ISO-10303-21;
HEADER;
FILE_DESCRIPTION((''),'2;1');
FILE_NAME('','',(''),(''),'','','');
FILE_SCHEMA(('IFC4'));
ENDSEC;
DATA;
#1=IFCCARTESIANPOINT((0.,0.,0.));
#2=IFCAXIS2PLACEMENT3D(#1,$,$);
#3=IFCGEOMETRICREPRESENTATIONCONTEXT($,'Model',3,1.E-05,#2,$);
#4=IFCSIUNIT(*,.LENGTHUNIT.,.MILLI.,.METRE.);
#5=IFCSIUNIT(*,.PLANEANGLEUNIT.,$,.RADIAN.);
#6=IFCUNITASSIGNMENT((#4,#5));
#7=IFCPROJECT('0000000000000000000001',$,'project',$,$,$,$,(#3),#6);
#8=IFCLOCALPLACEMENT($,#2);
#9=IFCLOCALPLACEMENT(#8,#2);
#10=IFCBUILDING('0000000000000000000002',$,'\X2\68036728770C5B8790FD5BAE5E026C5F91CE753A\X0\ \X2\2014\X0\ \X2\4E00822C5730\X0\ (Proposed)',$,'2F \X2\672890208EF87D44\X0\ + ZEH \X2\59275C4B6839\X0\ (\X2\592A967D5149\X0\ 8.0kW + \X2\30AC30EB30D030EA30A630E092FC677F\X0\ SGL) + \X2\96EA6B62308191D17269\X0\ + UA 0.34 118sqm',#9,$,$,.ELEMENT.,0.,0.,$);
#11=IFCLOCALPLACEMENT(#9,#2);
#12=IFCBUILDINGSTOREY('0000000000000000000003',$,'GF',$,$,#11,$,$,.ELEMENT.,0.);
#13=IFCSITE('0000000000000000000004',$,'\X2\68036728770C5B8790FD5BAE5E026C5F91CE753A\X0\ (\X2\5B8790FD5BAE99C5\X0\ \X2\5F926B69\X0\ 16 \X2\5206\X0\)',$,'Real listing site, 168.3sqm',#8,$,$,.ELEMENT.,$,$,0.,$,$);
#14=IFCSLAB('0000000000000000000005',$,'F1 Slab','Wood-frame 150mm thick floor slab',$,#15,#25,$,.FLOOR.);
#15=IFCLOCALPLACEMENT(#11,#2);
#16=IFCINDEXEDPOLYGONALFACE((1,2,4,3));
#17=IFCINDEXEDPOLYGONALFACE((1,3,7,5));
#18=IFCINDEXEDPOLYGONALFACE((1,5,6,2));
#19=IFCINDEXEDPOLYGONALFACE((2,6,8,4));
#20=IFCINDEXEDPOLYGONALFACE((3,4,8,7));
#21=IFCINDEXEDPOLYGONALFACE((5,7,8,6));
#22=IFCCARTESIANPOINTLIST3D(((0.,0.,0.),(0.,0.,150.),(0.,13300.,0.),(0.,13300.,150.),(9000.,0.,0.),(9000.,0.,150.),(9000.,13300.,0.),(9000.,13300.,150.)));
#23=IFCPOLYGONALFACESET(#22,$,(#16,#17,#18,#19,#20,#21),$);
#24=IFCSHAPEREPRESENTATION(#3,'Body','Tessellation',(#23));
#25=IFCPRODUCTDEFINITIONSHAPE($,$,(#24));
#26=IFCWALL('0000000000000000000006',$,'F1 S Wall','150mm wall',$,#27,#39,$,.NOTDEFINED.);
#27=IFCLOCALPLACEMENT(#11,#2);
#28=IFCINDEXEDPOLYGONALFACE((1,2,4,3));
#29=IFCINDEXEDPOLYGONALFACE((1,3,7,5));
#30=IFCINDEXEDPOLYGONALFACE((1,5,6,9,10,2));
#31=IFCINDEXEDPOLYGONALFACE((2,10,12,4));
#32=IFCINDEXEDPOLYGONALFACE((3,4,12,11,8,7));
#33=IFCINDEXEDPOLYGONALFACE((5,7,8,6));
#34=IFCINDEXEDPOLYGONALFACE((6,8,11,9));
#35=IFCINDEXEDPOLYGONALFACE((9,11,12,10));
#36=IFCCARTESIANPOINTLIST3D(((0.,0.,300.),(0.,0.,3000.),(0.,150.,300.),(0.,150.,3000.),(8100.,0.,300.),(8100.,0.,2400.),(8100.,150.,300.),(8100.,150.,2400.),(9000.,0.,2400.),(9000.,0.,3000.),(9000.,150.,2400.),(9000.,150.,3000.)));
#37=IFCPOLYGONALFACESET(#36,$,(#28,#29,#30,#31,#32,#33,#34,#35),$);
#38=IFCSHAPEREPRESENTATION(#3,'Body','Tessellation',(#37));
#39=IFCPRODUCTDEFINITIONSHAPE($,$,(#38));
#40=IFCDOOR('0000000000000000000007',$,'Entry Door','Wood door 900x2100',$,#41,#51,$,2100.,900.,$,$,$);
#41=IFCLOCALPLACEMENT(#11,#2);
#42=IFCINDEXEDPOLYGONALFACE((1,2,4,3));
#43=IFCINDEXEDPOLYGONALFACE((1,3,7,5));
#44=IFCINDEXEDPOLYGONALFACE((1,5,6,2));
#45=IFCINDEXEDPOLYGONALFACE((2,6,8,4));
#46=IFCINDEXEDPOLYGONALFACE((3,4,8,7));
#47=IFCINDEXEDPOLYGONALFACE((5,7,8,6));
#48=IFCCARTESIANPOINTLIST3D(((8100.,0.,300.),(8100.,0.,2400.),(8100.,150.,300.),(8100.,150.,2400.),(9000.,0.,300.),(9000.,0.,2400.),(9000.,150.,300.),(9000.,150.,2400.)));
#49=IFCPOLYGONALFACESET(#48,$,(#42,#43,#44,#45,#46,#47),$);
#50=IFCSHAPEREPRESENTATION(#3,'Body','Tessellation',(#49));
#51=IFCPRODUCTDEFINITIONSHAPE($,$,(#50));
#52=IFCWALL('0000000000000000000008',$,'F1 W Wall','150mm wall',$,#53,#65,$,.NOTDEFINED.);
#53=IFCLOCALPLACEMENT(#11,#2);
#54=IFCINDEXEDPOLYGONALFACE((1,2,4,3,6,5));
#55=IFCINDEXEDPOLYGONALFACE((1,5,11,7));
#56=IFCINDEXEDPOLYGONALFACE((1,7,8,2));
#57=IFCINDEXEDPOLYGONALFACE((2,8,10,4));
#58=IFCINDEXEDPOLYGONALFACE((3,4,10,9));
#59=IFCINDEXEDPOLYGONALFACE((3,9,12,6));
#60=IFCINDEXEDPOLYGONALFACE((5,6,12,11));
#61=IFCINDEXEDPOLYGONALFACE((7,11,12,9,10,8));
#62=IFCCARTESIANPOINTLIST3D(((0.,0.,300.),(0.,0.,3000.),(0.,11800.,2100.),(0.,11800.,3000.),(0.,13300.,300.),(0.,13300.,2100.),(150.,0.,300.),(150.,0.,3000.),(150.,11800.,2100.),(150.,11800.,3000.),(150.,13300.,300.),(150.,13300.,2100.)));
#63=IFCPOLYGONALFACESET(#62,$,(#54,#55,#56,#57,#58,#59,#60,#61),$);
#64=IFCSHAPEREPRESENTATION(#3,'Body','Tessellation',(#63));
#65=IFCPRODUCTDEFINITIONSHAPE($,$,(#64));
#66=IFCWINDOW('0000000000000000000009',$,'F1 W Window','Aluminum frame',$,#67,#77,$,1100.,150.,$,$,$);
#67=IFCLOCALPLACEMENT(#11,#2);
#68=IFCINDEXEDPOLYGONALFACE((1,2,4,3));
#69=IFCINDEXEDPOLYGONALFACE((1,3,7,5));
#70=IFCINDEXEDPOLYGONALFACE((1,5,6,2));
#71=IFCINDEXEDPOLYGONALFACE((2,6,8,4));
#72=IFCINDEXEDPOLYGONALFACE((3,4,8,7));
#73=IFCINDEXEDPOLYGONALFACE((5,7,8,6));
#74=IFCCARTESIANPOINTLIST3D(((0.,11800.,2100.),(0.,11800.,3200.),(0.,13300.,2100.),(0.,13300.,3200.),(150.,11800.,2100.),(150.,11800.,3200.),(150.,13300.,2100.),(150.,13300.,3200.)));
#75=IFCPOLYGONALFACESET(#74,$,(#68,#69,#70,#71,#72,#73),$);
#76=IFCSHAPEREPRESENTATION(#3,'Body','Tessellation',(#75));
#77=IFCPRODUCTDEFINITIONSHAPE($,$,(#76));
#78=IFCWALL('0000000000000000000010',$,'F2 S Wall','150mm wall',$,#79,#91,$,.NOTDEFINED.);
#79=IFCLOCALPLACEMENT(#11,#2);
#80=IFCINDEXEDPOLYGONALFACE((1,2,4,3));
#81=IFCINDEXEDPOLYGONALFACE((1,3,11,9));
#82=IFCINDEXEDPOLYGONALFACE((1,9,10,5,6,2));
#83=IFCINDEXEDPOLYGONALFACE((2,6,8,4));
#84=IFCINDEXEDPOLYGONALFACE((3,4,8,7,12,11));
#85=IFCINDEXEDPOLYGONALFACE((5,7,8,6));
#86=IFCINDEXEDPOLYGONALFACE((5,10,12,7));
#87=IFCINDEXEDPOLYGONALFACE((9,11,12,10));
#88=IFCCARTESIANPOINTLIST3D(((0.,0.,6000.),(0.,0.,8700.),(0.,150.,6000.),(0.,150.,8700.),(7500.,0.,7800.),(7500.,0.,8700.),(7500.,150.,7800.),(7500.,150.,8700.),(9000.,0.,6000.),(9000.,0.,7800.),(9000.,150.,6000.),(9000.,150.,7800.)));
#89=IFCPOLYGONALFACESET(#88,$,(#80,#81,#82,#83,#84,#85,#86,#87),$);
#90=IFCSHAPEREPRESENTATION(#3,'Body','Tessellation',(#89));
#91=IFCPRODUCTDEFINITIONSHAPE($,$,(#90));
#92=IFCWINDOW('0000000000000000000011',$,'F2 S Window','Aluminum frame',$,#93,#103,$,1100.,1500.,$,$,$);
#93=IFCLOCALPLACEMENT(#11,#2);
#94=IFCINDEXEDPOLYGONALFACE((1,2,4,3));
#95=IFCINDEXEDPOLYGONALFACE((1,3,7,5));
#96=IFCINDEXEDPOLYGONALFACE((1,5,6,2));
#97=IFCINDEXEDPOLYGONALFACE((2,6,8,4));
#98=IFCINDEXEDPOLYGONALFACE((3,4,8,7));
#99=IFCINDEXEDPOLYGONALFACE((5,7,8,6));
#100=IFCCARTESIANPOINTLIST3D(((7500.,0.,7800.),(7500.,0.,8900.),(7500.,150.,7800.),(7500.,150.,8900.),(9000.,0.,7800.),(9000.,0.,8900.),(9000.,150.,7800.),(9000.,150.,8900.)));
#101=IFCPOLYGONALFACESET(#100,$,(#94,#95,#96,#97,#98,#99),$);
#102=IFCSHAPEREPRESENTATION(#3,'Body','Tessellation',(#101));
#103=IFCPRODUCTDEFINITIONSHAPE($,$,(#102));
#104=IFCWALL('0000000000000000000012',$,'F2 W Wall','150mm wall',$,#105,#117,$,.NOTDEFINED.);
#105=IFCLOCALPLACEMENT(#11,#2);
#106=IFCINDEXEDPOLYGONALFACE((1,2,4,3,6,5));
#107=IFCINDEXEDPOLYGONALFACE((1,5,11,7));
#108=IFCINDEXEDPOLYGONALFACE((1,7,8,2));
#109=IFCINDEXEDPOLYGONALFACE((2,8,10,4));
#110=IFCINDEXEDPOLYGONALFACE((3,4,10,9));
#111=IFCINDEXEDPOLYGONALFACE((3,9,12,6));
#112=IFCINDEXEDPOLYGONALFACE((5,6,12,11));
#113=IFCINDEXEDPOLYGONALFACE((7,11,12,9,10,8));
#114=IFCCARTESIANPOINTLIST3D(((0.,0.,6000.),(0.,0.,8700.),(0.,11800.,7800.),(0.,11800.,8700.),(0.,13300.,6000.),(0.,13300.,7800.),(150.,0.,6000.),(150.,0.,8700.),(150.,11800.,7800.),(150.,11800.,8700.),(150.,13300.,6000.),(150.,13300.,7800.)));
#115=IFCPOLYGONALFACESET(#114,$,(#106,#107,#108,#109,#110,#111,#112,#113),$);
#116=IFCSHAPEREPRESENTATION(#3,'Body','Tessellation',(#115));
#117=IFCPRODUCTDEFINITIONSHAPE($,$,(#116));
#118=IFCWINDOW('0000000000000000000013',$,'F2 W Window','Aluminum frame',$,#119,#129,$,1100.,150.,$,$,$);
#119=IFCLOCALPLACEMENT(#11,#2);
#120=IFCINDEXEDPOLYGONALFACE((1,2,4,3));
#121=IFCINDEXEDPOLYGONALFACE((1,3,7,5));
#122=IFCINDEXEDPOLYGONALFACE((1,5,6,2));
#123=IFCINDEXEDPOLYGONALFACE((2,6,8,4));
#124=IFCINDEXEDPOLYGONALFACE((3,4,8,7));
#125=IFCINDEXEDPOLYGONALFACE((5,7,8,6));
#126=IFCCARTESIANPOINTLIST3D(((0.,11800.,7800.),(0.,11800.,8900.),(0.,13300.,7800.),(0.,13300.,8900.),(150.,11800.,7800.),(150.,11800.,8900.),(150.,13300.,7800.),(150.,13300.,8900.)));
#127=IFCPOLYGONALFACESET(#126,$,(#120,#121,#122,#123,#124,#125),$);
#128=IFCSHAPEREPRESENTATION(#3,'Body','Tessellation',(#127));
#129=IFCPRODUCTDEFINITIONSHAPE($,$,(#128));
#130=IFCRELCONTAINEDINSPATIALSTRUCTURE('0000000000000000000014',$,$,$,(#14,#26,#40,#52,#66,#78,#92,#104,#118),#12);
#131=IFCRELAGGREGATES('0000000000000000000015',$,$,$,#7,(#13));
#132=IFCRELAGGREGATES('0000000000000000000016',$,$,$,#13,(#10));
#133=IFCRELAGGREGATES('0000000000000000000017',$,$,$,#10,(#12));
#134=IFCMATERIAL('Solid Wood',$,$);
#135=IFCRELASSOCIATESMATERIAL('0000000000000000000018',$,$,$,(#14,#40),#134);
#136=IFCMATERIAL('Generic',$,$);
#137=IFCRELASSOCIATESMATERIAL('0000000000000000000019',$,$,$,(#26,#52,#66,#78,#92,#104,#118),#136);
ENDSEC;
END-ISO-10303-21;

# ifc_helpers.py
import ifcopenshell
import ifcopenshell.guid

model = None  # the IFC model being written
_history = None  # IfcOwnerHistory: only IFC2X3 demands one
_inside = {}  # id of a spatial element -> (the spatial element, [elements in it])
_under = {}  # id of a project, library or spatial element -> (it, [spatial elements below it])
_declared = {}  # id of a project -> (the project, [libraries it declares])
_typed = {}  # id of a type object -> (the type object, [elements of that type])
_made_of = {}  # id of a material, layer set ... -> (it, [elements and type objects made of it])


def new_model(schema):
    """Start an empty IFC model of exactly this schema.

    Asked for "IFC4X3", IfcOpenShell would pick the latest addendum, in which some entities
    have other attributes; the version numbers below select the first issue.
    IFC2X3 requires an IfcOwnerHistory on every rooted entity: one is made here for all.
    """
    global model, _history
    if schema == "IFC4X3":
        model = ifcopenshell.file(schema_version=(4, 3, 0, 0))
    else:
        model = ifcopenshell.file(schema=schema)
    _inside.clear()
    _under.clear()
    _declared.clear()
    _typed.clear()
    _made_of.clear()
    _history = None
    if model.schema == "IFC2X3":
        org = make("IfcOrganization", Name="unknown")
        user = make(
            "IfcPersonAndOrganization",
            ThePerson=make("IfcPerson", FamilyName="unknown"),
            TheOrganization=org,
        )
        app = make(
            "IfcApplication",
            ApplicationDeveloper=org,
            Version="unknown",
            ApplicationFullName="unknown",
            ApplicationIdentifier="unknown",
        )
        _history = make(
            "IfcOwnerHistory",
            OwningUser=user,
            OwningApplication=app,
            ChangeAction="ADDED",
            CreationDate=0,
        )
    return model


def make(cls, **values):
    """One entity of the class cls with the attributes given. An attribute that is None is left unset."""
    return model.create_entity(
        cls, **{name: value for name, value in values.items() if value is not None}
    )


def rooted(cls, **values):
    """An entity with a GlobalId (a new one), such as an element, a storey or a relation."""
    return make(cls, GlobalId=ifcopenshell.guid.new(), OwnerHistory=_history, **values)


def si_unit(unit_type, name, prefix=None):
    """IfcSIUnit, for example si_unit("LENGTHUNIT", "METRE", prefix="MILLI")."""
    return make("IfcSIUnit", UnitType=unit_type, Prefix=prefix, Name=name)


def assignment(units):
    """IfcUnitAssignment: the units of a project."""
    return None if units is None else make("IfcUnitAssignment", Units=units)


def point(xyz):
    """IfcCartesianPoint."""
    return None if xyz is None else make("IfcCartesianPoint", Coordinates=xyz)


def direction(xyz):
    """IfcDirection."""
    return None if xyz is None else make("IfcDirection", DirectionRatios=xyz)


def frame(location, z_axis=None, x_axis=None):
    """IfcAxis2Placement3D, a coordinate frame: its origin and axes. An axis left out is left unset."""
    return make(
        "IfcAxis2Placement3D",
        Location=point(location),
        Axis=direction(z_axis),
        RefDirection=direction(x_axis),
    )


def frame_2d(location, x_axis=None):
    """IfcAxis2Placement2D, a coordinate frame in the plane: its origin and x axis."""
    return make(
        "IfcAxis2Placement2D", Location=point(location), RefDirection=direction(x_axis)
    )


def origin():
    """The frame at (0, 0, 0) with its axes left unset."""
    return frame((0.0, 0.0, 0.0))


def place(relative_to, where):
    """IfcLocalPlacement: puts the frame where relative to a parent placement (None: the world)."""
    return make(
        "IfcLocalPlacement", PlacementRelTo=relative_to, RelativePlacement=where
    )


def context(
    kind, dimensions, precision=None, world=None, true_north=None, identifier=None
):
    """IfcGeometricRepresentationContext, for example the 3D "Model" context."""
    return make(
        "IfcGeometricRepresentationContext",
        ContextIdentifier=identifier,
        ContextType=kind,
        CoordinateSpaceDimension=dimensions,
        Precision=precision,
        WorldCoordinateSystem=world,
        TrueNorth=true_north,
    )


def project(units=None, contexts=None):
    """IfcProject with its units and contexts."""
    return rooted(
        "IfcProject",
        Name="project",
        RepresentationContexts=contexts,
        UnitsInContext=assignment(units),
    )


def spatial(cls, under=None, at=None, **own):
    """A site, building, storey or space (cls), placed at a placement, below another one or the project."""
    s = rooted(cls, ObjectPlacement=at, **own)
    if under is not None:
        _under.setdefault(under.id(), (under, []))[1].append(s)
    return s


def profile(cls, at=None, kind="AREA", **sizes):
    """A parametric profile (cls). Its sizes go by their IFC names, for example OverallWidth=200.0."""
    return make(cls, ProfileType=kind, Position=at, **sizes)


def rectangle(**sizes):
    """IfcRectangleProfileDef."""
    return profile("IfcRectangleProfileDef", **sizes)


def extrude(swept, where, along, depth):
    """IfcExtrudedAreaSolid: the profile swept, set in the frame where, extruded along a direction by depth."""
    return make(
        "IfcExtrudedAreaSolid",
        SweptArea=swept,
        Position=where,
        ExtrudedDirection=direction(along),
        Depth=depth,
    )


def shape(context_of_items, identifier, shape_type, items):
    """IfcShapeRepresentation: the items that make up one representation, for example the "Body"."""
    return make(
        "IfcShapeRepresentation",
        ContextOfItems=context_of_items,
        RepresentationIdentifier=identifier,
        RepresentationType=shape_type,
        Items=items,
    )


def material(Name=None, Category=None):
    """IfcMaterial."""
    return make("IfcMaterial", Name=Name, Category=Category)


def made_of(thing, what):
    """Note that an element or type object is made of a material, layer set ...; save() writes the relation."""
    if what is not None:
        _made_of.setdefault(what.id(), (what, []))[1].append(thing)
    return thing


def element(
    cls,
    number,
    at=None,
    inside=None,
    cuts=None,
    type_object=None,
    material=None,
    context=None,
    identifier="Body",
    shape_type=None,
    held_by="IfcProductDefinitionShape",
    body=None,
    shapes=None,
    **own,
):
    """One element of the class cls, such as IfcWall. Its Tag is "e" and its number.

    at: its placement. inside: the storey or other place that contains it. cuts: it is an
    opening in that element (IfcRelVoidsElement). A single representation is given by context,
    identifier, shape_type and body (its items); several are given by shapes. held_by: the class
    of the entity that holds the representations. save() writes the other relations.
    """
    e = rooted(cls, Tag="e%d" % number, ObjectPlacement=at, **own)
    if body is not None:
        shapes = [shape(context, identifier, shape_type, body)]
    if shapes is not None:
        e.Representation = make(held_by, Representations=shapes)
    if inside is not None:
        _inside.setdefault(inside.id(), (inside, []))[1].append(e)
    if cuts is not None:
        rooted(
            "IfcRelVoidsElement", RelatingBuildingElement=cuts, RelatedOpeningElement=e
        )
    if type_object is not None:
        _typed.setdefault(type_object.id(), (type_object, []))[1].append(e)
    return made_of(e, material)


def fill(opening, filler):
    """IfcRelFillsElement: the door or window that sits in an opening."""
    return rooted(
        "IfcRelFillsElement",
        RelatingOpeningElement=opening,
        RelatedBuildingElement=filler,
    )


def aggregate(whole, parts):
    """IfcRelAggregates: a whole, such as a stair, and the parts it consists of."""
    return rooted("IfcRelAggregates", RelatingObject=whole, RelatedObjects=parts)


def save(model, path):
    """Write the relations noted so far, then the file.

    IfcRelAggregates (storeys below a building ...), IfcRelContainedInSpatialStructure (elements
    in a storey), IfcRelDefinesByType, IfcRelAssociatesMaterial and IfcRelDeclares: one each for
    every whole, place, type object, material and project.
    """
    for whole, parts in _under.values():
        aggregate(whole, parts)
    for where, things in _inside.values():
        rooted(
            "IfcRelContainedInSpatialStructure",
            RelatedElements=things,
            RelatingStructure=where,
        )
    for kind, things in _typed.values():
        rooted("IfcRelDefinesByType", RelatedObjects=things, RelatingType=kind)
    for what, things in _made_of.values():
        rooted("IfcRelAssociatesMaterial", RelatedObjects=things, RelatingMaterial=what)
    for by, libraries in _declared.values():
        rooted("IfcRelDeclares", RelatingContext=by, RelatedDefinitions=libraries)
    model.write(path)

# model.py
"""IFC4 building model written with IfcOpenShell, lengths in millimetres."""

from ifc_helpers import new_model, si_unit, frame, frame_2d, origin, place, context, project, spatial, rectangle, extrude, material, element, fill, save


model = new_model("IFC4")

# Units and contexts
model_context = context("Model", 3, precision=1e-05, world=origin())
ifc_project = project(units=[si_unit("LENGTHUNIT", "METRE", prefix="MILLI"), si_unit("PLANEANGLEUNIT", "RADIAN")], contexts=[model_context])

# Site, building, storey
site_placement = place(None, origin())
site = spatial("IfcSite", under=ifc_project, at=site_placement, Name="栃木県宇都宮市江野町 (宇都宮駅 徒歩 16 分)", ObjectType="Real listing site, 168.3sqm", CompositionType="ELEMENT", RefElevation=0.0)
building_placement = place(site_placement, origin())
building = spatial("IfcBuilding", under=site, at=building_placement, Name="栃木県宇都宮市江野町 — 一般地 (Proposed)", ObjectType="2F 木造軸組 + ZEH 大屋根 (太陽光 8.0kW + ガルバリウム鋼板 SGL) + 雪止め金物 + UA 0.34 118sqm", CompositionType="ELEMENT", ElevationOfRefHeight=0.0, ElevationOfTerrain=0.0)
storey_placement = place(building_placement, origin())
storey = spatial("IfcBuildingStorey", under=building, at=storey_placement, Name="GF", CompositionType="ELEMENT", Elevation=0.0)

# Slab
ifc_material_1 = material(Name="Solid Wood")
slab_1_placement = place(storey_placement, origin())
element("IfcSlab", 1, at=slab_1_placement, inside=storey, material=ifc_material_1, Name="F1 Slab", Description="Wood-frame 150mm thick floor slab", PredefinedType="FLOOR", context=model_context, shape_type="SweptSolid", body=[
    extrude(rectangle(XDim=9000.0, YDim=13300.0, at=frame_2d((4500.0, 6650.0))), origin(), (0.0, 0.0, 1.0), 150.0),
])

# Shared definitions
ifc_material_2 = material(Name="Generic")

# Wall, opening, door
wall_1_placement = place(storey_placement, frame((0.0, 0.0, 150.0)))
wall_1 = element("IfcWall", 2, at=wall_1_placement, inside=storey, material=ifc_material_2, Name="F1 S Wall", Description="150mm wall", PredefinedType="NOTDEFINED", context=model_context, shape_type="SweptSolid", body=[
    extrude(rectangle(XDim=9000.0, YDim=150.0, at=frame_2d((4500.0, 75.0))), frame((0.0, 0.0, 150.0)), (0.0, 0.0, 1.0), 2700.0),
])
opening_1_placement = place(storey_placement, frame((4050.0, 0.0, 150.0)))
opening_1 = element("IfcOpeningElement", 3, at=opening_1_placement, cuts=wall_1, PredefinedType="NOTDEFINED", context=model_context, shape_type="SweptSolid", body=[
    extrude(rectangle(XDim=900.0, YDim=150.0, at=frame_2d((450.0, 75.0))), frame((4050.0, 0.0, 150.0)), (0.0, 0.0, 1.0), 2100.0),
])
door_placement = place(storey_placement, frame((4050.0, 0.0, 150.0)))
door = element("IfcDoor", 4, at=door_placement, inside=storey, material=ifc_material_1, Name="Entry Door", Description="Wood door 900x2100", OverallHeight=2100.0, OverallWidth=900.0, context=model_context, shape_type="SweptSolid", body=[
    extrude(rectangle(XDim=900.0, YDim=150.0, at=frame_2d((450.0, 75.0))), frame((4050.0, 0.0, 150.0)), (0.0, 0.0, 1.0), 2100.0),
])
fill(opening_1, door)

# Walls, openings, windows
wall_2_placement = place(storey_placement, frame((0.0, 0.0, 150.0)))
wall_2 = element("IfcWall", 5, at=wall_2_placement, inside=storey, material=ifc_material_2, Name="F1 W Wall", Description="150mm wall", PredefinedType="NOTDEFINED", context=model_context, shape_type="SweptSolid", body=[
    extrude(rectangle(XDim=150.0, YDim=13300.0, at=frame_2d((75.0, 6650.0))), frame((0.0, 0.0, 150.0)), (0.0, 0.0, 1.0), 2700.0),
])
opening_2_placement = place(storey_placement, frame((0.0, 5900.0, 1050.0)))
opening_2 = element("IfcOpeningElement", 6, at=opening_2_placement, cuts=wall_2, PredefinedType="NOTDEFINED", context=model_context, shape_type="SweptSolid", body=[
    extrude(rectangle(XDim=150.0, YDim=1500.0, at=frame_2d((75.0, 750.0))), frame((0.0, 5900.0, 1050.0)), (0.0, 0.0, 1.0), 1100.0),
])
window_1_placement = place(storey_placement, frame((0.0, 5900.0, 1050.0)))
window_1 = element("IfcWindow", 7, at=window_1_placement, inside=storey, material=ifc_material_2, Name="F1 W Window", Description="Aluminum frame", OverallHeight=1100.0, OverallWidth=150.0, context=model_context, shape_type="SweptSolid", body=[
    extrude(rectangle(XDim=150.0, YDim=1500.0, at=frame_2d((75.0, 750.0))), frame((0.0, 5900.0, 1050.0)), (0.0, 0.0, 1.0), 1100.0),
])
fill(opening_2, window_1)
wall_3_placement = place(storey_placement, frame((0.0, 0.0, 3000.0)))
wall_3 = element("IfcWall", 8, at=wall_3_placement, inside=storey, material=ifc_material_2, Name="F2 S Wall", Description="150mm wall", PredefinedType="NOTDEFINED", context=model_context, shape_type="SweptSolid", body=[
    extrude(rectangle(XDim=9000.0, YDim=150.0, at=frame_2d((4500.0, 75.0))), frame((0.0, 0.0, 3000.0)), (0.0, 0.0, 1.0), 2700.0),
])
opening_3_placement = place(storey_placement, frame((3750.0, 0.0, 3900.0)))
opening_3 = element("IfcOpeningElement", 9, at=opening_3_placement, cuts=wall_3, PredefinedType="NOTDEFINED", context=model_context, shape_type="SweptSolid", body=[
    extrude(rectangle(XDim=1500.0, YDim=150.0, at=frame_2d((750.0, 75.0))), frame((3750.0, 0.0, 3900.0)), (0.0, 0.0, 1.0), 1100.0),
])
window_2_placement = place(storey_placement, frame((3750.0, 0.0, 3900.0)))
window_2 = element("IfcWindow", 10, at=window_2_placement, inside=storey, material=ifc_material_2, Name="F2 S Window", Description="Aluminum frame", OverallHeight=1100.0, OverallWidth=1500.0, context=model_context, shape_type="SweptSolid", body=[
    extrude(rectangle(XDim=1500.0, YDim=150.0, at=frame_2d((750.0, 75.0))), frame((3750.0, 0.0, 3900.0)), (0.0, 0.0, 1.0), 1100.0),
])
fill(opening_3, window_2)
wall_4_placement = place(storey_placement, frame((0.0, 0.0, 3000.0)))
wall_4 = element("IfcWall", 11, at=wall_4_placement, inside=storey, material=ifc_material_2, Name="F2 W Wall", Description="150mm wall", PredefinedType="NOTDEFINED", context=model_context, shape_type="SweptSolid", body=[
    extrude(rectangle(XDim=150.0, YDim=13300.0, at=frame_2d((75.0, 6650.0))), frame((0.0, 0.0, 3000.0)), (0.0, 0.0, 1.0), 2700.0),
])
opening_4_placement = place(storey_placement, frame((0.0, 5900.0, 3900.0)))
opening_4 = element("IfcOpeningElement", 12, at=opening_4_placement, cuts=wall_4, PredefinedType="NOTDEFINED", context=model_context, shape_type="SweptSolid", body=[
    extrude(rectangle(XDim=150.0, YDim=1500.0, at=frame_2d((75.0, 750.0))), frame((0.0, 5900.0, 3900.0)), (0.0, 0.0, 1.0), 1100.0),
])
window_3_placement = place(storey_placement, frame((0.0, 5900.0, 3900.0)))
window_3 = element("IfcWindow", 13, at=window_3_placement, inside=storey, material=ifc_material_2, Name="F2 W Window", Description="Aluminum frame", OverallHeight=1100.0, OverallWidth=150.0, context=model_context, shape_type="SweptSolid", body=[
    extrude(rectangle(XDim=150.0, YDim=1500.0, at=frame_2d((75.0, 750.0))), frame((0.0, 5900.0, 3900.0)), (0.0, 0.0, 1.0), 1100.0),
])
fill(opening_4, window_3)

save(model, "model.ifc")
